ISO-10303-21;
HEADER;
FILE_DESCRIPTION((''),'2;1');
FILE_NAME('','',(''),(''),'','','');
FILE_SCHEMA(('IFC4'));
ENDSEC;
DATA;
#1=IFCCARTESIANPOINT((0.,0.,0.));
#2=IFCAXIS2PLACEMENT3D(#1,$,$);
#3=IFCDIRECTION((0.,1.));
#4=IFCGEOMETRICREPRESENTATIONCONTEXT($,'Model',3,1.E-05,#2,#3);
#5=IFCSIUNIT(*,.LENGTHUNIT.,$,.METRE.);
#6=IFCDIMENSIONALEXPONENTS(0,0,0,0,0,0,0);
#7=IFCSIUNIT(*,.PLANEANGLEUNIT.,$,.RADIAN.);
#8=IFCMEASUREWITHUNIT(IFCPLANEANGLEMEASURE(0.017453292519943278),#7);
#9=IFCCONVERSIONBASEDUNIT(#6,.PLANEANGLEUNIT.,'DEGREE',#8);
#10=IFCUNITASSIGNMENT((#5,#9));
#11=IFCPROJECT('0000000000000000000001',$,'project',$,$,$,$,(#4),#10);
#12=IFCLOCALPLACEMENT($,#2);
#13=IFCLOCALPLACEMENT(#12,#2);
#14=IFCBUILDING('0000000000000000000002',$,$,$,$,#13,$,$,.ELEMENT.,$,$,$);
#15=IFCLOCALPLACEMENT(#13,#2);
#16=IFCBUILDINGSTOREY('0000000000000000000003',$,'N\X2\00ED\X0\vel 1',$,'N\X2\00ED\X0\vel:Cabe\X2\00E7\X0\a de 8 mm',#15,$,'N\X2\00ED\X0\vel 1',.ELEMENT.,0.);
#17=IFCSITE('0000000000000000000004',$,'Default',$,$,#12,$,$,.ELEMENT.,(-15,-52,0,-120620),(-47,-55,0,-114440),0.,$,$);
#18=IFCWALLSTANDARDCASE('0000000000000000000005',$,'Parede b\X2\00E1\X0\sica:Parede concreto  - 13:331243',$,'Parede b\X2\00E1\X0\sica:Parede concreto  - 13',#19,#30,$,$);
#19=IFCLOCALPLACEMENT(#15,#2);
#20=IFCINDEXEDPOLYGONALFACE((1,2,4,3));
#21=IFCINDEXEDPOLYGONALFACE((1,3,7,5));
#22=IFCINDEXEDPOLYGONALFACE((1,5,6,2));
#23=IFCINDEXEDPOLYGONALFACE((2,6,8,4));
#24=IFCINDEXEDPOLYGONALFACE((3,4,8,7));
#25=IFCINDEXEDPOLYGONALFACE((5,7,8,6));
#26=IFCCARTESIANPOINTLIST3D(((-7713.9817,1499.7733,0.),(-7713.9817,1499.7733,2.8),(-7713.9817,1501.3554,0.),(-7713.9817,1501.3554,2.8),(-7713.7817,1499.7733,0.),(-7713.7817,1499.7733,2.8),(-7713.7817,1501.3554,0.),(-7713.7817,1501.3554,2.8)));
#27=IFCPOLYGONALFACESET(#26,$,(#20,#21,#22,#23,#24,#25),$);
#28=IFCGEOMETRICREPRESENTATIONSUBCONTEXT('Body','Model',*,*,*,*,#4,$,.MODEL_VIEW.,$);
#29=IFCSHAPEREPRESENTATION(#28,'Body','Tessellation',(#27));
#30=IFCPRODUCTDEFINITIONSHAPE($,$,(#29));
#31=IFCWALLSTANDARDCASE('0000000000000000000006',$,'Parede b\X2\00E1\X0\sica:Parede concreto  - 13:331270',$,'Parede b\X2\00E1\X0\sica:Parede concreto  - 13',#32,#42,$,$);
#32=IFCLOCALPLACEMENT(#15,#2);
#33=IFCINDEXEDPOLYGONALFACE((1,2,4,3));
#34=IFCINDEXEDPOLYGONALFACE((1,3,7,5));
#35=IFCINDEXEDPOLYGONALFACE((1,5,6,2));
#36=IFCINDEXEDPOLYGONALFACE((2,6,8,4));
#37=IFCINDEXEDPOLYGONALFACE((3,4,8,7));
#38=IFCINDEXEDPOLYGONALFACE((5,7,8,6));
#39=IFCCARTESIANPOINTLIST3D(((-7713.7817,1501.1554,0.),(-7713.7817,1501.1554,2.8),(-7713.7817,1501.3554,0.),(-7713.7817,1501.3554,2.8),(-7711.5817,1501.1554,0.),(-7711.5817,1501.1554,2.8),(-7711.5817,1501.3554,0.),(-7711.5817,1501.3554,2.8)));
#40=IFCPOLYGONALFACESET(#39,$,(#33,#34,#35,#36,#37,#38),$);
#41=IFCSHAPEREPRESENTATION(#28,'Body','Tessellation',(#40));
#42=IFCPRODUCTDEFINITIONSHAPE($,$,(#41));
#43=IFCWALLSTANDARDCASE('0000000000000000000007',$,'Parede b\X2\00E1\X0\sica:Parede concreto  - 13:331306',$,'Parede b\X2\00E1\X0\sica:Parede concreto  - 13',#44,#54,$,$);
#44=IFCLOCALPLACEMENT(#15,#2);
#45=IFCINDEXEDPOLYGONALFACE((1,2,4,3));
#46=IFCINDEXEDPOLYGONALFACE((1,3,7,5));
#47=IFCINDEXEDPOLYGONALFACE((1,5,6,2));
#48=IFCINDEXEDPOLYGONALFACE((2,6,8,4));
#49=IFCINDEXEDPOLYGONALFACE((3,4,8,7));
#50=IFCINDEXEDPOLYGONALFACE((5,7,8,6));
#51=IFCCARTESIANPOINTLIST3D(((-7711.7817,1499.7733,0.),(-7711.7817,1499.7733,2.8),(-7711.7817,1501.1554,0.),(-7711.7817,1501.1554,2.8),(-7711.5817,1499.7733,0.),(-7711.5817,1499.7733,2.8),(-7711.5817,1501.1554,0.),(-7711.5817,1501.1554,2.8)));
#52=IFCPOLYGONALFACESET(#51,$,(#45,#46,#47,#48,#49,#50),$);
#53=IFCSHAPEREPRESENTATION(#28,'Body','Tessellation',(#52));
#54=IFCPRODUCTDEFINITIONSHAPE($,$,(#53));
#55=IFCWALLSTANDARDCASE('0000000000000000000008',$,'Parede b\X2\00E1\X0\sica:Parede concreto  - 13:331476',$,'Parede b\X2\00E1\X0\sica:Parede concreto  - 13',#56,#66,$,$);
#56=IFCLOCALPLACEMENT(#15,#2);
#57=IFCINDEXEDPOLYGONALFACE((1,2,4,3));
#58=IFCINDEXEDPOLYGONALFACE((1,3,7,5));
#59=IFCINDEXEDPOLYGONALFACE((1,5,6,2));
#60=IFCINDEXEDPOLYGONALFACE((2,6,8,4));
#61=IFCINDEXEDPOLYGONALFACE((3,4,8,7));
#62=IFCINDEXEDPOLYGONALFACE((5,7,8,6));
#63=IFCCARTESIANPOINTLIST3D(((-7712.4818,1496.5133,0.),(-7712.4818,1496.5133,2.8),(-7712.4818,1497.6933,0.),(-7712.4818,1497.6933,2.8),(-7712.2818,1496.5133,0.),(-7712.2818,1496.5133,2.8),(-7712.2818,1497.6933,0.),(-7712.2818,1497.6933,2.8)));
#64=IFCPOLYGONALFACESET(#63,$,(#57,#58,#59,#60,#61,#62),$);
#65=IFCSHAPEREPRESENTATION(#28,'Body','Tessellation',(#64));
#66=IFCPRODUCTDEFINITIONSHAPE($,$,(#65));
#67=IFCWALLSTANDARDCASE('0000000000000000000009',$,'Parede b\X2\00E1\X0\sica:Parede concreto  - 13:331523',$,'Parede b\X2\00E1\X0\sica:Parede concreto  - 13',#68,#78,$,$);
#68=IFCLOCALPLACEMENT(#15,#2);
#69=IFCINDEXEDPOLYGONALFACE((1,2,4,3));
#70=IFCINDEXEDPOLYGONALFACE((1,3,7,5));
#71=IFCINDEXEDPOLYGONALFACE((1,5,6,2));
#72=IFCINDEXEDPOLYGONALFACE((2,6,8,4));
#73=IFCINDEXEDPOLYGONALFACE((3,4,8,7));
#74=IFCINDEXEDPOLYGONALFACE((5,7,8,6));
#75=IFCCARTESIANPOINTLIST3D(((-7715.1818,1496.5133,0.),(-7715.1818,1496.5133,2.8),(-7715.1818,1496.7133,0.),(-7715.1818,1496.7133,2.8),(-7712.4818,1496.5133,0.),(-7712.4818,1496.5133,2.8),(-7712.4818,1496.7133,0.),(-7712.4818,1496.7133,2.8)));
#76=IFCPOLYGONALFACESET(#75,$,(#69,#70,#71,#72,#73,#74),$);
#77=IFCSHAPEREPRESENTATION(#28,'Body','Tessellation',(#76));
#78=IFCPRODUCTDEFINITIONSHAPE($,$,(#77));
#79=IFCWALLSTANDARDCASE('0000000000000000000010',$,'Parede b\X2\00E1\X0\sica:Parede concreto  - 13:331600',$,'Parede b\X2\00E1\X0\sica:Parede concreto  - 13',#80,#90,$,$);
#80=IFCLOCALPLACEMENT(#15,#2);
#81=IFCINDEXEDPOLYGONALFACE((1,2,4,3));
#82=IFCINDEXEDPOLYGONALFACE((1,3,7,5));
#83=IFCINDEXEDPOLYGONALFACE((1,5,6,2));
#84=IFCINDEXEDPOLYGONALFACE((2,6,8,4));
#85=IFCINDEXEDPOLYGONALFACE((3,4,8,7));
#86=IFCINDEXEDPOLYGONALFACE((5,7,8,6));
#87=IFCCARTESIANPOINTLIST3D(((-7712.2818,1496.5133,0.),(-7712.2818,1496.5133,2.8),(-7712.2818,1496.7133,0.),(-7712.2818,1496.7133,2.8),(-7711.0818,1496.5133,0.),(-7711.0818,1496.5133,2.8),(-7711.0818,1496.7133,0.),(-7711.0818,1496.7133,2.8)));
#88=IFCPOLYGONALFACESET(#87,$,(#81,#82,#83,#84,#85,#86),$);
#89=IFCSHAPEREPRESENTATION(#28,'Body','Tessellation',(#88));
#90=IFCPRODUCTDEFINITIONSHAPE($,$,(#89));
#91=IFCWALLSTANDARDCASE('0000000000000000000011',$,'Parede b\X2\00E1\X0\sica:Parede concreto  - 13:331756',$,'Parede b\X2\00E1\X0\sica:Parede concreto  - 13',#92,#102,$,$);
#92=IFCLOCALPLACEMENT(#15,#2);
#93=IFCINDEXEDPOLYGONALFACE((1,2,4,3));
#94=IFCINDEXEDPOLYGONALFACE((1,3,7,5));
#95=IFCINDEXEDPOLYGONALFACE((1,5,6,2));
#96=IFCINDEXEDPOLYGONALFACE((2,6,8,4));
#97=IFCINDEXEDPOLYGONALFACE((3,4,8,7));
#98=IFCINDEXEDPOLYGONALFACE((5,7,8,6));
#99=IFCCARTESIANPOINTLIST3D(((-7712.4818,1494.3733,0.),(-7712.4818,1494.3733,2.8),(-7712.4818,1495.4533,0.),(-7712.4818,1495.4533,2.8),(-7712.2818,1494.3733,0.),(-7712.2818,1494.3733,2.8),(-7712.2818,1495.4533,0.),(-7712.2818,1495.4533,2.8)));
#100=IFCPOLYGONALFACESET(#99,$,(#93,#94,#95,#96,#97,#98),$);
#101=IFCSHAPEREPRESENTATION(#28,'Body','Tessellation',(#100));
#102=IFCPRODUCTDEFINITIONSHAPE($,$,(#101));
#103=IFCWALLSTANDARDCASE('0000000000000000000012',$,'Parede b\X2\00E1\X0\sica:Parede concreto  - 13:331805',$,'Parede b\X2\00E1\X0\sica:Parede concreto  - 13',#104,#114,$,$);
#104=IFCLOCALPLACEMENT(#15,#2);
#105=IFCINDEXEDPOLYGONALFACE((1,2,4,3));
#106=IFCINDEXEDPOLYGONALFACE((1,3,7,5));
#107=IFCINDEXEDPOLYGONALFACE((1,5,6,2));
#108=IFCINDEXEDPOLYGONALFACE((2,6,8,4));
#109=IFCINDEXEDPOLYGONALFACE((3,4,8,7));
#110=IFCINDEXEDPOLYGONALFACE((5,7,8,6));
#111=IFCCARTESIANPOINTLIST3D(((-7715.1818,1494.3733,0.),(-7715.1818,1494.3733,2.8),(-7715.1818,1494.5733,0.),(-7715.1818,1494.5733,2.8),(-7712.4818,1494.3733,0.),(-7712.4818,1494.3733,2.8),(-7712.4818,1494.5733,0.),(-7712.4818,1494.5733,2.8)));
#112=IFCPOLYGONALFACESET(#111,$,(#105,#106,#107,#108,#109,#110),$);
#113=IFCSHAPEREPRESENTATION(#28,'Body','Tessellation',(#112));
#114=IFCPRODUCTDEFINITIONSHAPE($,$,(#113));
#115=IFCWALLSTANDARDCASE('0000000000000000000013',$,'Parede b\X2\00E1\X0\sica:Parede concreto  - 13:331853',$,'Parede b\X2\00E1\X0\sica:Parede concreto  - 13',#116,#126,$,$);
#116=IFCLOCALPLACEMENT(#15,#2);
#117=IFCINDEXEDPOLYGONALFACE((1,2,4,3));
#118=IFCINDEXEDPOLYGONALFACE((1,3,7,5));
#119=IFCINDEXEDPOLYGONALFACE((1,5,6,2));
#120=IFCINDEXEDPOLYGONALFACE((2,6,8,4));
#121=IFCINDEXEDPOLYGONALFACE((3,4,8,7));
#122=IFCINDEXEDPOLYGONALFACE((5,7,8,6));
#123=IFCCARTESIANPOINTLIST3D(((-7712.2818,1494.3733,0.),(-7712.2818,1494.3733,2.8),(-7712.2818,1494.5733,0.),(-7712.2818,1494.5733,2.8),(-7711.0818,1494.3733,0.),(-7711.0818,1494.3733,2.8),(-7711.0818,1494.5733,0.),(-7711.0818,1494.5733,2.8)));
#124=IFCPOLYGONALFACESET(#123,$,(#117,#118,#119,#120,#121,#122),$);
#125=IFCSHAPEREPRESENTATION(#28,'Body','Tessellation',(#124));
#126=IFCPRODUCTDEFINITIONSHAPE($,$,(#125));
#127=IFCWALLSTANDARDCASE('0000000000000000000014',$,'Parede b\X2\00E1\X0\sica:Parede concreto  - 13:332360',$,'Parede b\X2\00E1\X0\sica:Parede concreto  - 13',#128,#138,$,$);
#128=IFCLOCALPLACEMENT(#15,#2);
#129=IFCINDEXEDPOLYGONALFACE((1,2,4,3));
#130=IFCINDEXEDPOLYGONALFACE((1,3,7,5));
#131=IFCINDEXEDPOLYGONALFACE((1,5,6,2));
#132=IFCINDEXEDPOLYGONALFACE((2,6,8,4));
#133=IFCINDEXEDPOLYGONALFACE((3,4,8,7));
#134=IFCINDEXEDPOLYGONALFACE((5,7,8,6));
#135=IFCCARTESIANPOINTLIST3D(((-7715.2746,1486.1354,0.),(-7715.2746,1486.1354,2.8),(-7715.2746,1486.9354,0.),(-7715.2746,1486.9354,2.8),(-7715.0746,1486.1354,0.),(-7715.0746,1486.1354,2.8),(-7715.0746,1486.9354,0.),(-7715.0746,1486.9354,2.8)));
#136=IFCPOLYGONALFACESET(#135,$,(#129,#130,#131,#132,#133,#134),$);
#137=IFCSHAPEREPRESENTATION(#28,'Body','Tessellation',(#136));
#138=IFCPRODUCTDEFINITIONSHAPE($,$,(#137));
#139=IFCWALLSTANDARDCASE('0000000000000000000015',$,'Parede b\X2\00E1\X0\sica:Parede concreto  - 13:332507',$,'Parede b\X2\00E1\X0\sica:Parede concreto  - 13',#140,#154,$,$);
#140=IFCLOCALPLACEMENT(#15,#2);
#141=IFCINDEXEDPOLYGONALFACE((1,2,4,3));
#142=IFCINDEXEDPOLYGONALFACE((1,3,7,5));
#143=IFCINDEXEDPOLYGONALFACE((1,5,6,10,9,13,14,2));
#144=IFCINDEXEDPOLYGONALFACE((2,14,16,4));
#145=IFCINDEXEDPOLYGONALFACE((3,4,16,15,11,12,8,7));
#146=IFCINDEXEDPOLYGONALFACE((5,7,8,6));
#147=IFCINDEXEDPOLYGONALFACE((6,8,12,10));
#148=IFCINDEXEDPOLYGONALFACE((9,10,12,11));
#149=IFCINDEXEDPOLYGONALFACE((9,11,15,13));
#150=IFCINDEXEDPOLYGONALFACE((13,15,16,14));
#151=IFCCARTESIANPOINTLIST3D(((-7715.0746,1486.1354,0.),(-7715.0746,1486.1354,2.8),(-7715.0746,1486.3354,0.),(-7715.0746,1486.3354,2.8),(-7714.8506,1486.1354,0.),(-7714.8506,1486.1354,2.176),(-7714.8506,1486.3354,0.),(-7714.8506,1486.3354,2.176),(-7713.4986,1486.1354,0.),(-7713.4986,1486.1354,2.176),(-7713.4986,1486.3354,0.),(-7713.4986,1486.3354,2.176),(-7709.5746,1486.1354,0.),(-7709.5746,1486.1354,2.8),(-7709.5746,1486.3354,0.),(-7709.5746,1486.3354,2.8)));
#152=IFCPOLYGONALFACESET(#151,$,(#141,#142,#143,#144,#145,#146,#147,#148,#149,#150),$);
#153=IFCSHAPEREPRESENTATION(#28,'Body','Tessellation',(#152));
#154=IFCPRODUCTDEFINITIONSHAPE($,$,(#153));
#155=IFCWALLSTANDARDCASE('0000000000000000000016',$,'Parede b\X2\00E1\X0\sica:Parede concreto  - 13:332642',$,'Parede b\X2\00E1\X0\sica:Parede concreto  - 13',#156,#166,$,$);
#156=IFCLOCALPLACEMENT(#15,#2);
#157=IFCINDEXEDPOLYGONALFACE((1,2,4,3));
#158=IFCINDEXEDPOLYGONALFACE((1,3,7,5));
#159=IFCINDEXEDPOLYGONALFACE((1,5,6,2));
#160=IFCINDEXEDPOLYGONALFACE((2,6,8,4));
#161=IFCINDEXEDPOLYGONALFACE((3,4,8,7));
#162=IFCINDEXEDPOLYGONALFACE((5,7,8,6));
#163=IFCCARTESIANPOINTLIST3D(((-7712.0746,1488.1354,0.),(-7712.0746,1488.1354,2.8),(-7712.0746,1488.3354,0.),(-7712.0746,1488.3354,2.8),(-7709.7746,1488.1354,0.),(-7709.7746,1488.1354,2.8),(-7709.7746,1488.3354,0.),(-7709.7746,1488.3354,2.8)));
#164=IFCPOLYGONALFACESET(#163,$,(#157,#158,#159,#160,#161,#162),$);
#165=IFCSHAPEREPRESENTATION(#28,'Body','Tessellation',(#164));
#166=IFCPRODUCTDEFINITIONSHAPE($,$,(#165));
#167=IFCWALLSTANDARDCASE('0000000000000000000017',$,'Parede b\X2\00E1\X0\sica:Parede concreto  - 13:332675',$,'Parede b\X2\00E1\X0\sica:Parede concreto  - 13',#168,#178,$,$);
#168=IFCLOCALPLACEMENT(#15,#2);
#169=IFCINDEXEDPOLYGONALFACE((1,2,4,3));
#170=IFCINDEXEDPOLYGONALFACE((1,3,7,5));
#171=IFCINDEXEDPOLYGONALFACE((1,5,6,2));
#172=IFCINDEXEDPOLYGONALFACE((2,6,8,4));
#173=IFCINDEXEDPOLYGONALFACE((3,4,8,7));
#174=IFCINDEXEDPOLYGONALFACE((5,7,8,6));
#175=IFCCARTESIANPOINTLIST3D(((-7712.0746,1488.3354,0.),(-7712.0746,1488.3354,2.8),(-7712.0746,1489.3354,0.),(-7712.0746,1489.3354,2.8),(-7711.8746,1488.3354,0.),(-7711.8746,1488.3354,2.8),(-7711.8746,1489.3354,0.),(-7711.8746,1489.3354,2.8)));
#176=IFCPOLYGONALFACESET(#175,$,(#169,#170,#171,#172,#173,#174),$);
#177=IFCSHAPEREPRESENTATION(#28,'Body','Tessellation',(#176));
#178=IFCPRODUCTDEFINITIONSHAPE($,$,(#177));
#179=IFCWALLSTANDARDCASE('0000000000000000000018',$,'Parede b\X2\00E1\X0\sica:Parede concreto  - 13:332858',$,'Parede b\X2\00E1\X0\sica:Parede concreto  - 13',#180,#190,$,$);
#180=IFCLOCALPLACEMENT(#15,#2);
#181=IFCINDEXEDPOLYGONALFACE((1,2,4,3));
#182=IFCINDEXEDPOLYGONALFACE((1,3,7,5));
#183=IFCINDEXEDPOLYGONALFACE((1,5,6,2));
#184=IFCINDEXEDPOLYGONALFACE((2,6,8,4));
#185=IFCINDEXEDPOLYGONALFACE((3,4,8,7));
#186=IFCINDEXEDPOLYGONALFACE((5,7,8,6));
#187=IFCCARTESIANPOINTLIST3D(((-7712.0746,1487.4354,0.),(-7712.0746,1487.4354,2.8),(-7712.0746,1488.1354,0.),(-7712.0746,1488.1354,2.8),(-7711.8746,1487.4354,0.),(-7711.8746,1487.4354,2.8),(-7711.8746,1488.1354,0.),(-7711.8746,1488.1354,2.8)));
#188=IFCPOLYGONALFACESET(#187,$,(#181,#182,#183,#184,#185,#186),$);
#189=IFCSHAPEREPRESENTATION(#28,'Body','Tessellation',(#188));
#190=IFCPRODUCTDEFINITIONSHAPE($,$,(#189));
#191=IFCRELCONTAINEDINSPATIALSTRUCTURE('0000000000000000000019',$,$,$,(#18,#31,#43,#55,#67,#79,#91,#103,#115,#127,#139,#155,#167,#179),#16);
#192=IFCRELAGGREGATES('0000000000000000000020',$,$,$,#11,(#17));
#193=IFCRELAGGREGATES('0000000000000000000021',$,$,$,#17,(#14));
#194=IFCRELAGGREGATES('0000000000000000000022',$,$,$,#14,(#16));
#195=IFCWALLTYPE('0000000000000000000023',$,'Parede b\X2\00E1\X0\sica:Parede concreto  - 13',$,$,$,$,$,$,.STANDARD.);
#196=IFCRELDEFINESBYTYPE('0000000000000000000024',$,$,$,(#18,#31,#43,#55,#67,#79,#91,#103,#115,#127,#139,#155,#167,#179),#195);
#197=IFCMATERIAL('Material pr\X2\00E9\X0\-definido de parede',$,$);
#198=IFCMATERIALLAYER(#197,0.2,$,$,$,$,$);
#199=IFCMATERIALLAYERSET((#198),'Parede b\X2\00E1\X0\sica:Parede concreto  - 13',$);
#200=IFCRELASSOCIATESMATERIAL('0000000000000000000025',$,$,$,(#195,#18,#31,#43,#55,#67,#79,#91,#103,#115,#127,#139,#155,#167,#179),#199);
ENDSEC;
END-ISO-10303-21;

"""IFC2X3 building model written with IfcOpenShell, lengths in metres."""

from ifc_helpers import new_model, entity, si_unit, converted_unit, direction, frame, frame_2d, origin, place, context, subcontext, project, spatial, rectangle, extrude, material, layer, layer_set, layer_usage, type_object, element, save


model = new_model("IFC2X3")

# Units and contexts
model_context = context("Model", 3, precision=1e-05, world=origin(), true_north=direction((0.0, 1.0)))
body_context = subcontext(model_context, "Body", "Model", "MODEL_VIEW")
ifc_project = project(units=[si_unit("LENGTHUNIT", "METRE"), converted_unit("PLANEANGLEUNIT", "DEGREE", entity("IfcPlaneAngleMeasure", 0.017453292519943278), si_unit("PLANEANGLEUNIT", "RADIAN"), dimensions=[0, 0, 0, 0, 0, 0, 0])], contexts=[model_context])

# Site, building, storey
site_placement = place(None, origin())
site = spatial("IfcSite", under=ifc_project, at=site_placement, Name="Default", CompositionType="ELEMENT", RefLatitude=(-15, -52, 0, -120620), RefLongitude=(-47, -55, 0, -114440), RefElevation=0.0)
building_placement = place(site_placement, origin())
building = spatial("IfcBuilding", under=site, at=building_placement, CompositionType="ELEMENT")
storey_placement = place(building_placement, origin())
storey = spatial("IfcBuildingStorey", under=building, at=storey_placement, Name="Nível 1", ObjectType="Nível:Cabeça de 8 mm", LongName="Nível 1", CompositionType="ELEMENT", Elevation=0.0)

# Walls
ifc_material = material(Name="Material pré-definido de parede")
ifc_layer = layer(ifc_material, 0.2)
ifc_layer_set = layer_set([ifc_layer], Name="Parede básica:Parede concreto  - 13")
ifc_layer_usage_1 = layer_usage(ifc_layer_set, "AXIS2", "NEGATIVE", 0.1)
wall_type = type_object("IfcWallType", Name="Parede básica:Parede concreto  - 13", PredefinedType="STANDARD", material=ifc_layer_set)
wall_1_placement = place(storey_placement, frame((-7713.8817, 1499.7733, 0.0), z_axis=(0.0, 0.0, 1.0), x_axis=(0.0, 1.0, 0.0)))
element("IfcWallStandardCase", 1, at=wall_1_placement, inside=storey, type_object=wall_type, material=ifc_layer_usage_1, Name="Parede básica:Parede concreto  - 13:331243", ObjectType="Parede básica:Parede concreto  - 13", context=body_context, shape_type="SweptSolid", body=[
    extrude(rectangle(XDim=1.5821, YDim=0.2, at=frame_2d((0.791, 0.0), x_axis=(-1.0, 0.0))), origin(), (0.0, 0.0, 1.0), 2.8),
])
ifc_layer_usage_2 = layer_usage(ifc_layer_set, "AXIS2", "NEGATIVE", 0.1)
wall_2_placement = place(storey_placement, frame((-7713.7817, 1501.2554, 0.0)))
element("IfcWallStandardCase", 2, at=wall_2_placement, inside=storey, type_object=wall_type, material=ifc_layer_usage_2, Name="Parede básica:Parede concreto  - 13:331270", ObjectType="Parede básica:Parede concreto  - 13", context=body_context, shape_type="SweptSolid", body=[
    extrude(rectangle(XDim=2.2, YDim=0.2, at=frame_2d((1.1, 0.0), x_axis=(-1.0, 0.0))), origin(), (0.0, 0.0, 1.0), 2.8),
])
ifc_layer_usage_3 = layer_usage(ifc_layer_set, "AXIS2", "NEGATIVE", 0.1)
wall_3_placement = place(storey_placement, frame((-7711.6817, 1501.1554, 0.0), z_axis=(0.0, 0.0, 1.0), x_axis=(0.0, -1.0, 0.0)))
element("IfcWallStandardCase", 3, at=wall_3_placement, inside=storey, type_object=wall_type, material=ifc_layer_usage_3, Name="Parede básica:Parede concreto  - 13:331306", ObjectType="Parede básica:Parede concreto  - 13", context=body_context, shape_type="SweptSolid", body=[
    extrude(rectangle(XDim=1.3821, YDim=0.2, at=frame_2d((0.691, 0.0), x_axis=(-1.0, 0.0))), origin(), (0.0, 0.0, 1.0), 2.8),
])
ifc_layer_usage_4 = layer_usage(ifc_layer_set, "AXIS2", "NEGATIVE", 0.1)
wall_4_placement = place(storey_placement, frame((-7712.3818, 1497.6933, 0.0), z_axis=(0.0, 0.0, 1.0), x_axis=(0.0, -1.0, 0.0)))
element("IfcWallStandardCase", 4, at=wall_4_placement, inside=storey, type_object=wall_type, material=ifc_layer_usage_4, Name="Parede básica:Parede concreto  - 13:331476", ObjectType="Parede básica:Parede concreto  - 13", context=body_context, shape_type="SweptSolid", body=[
    extrude(rectangle(XDim=1.18, YDim=0.2, at=frame_2d((0.59, 0.0), x_axis=(-1.0, 0.0))), origin(), (0.0, 0.0, 1.0), 2.8),
])
ifc_layer_usage_5 = layer_usage(ifc_layer_set, "AXIS2", "NEGATIVE", 0.1)
wall_5_placement = place(storey_placement, frame((-7712.4818, 1496.6133, 0.0), z_axis=(0.0, 0.0, 1.0), x_axis=(-1.0, 0.0, 0.0)))
element("IfcWallStandardCase", 5, at=wall_5_placement, inside=storey, type_object=wall_type, material=ifc_layer_usage_5, Name="Parede básica:Parede concreto  - 13:331523", ObjectType="Parede básica:Parede concreto  - 13", context=body_context, shape_type="SweptSolid", body=[
    extrude(rectangle(XDim=2.7, YDim=0.2, at=frame_2d((1.35, 0.0), x_axis=(-1.0, 0.0))), origin(), (0.0, 0.0, 1.0), 2.8),
])
ifc_layer_usage_6 = layer_usage(ifc_layer_set, "AXIS2", "POSITIVE", -0.1)
wall_6_placement = place(storey_placement, frame((-7712.2818, 1496.6133, 0.0)))
element("IfcWallStandardCase", 6, at=wall_6_placement, inside=storey, type_object=wall_type, material=ifc_layer_usage_6, Name="Parede básica:Parede concreto  - 13:331600", ObjectType="Parede básica:Parede concreto  - 13", context=body_context, shape_type="SweptSolid", body=[
    extrude(rectangle(XDim=1.2, YDim=0.2, at=frame_2d((0.6, 0.0), x_axis=(-1.0, 0.0))), origin(), (0.0, 0.0, 1.0), 2.8),
])
ifc_layer_usage_7 = layer_usage(ifc_layer_set, "AXIS2", "NEGATIVE", 0.1)
wall_7_placement = place(storey_placement, frame((-7712.3818, 1495.4533, 0.0), z_axis=(0.0, 0.0, 1.0), x_axis=(0.0, -1.0, 0.0)))
element("IfcWallStandardCase", 7, at=wall_7_placement, inside=storey, type_object=wall_type, material=ifc_layer_usage_7, Name="Parede básica:Parede concreto  - 13:331756", ObjectType="Parede básica:Parede concreto  - 13", context=body_context, shape_type="SweptSolid", body=[
    extrude(rectangle(XDim=1.08, YDim=0.2, at=frame_2d((0.54, 0.0), x_axis=(-1.0, 0.0))), origin(), (0.0, 0.0, 1.0), 2.8),
])
ifc_layer_usage_8 = layer_usage(ifc_layer_set, "AXIS2", "NEGATIVE", 0.1)
wall_8_placement = place(storey_placement, frame((-7712.4818, 1494.4733, 0.0), z_axis=(0.0, 0.0, 1.0), x_axis=(-1.0, 0.0, 0.0)))
element("IfcWallStandardCase", 8, at=wall_8_placement, inside=storey, type_object=wall_type, material=ifc_layer_usage_8, Name="Parede básica:Parede concreto  - 13:331805", ObjectType="Parede básica:Parede concreto  - 13", context=body_context, shape_type="SweptSolid", body=[
    extrude(rectangle(XDim=2.7, YDim=0.2, at=frame_2d((1.35, 0.0), x_axis=(-1.0, 0.0))), origin(), (0.0, 0.0, 1.0), 2.8),
])
ifc_layer_usage_9 = layer_usage(ifc_layer_set, "AXIS2", "POSITIVE", -0.1)
wall_9_placement = place(storey_placement, frame((-7712.2818, 1494.4733, 0.0)))
element("IfcWallStandardCase", 9, at=wall_9_placement, inside=storey, type_object=wall_type, material=ifc_layer_usage_9, Name="Parede básica:Parede concreto  - 13:331853", ObjectType="Parede básica:Parede concreto  - 13", context=body_context, shape_type="SweptSolid", body=[
    extrude(rectangle(XDim=1.2, YDim=0.2, at=frame_2d((0.6, 0.0), x_axis=(-1.0, 0.0))), origin(), (0.0, 0.0, 1.0), 2.8),
])
ifc_layer_usage_10 = layer_usage(ifc_layer_set, "AXIS2", "POSITIVE", -0.1)
wall_10_placement = place(storey_placement, frame((-7715.1746, 1486.9354, 0.0), z_axis=(0.0, 0.0, 1.0), x_axis=(0.0, -1.0, 0.0)))
element("IfcWallStandardCase", 10, at=wall_10_placement, inside=storey, type_object=wall_type, material=ifc_layer_usage_10, Name="Parede básica:Parede concreto  - 13:332360", ObjectType="Parede básica:Parede concreto  - 13", context=body_context, shape_type="SweptSolid", body=[
    extrude(rectangle(XDim=0.8, YDim=0.2, at=frame_2d((0.4, 0.0), x_axis=(-1.0, 0.0))), origin(), (0.0, 0.0, 1.0), 2.8),
])

# Wall, opening
ifc_layer_usage_11 = layer_usage(ifc_layer_set, "AXIS2", "NEGATIVE", 0.1)
wall_11_placement = place(storey_placement, frame((-7715.0746, 1486.2354, 0.0)))
wall_11 = element("IfcWallStandardCase", 11, at=wall_11_placement, inside=storey, type_object=wall_type, material=ifc_layer_usage_11, Name="Parede básica:Parede concreto  - 13:332507", ObjectType="Parede básica:Parede concreto  - 13", context=body_context, shape_type="SweptSolid", body=[
    extrude(rectangle(XDim=5.5, YDim=0.2, at=frame_2d((2.75, 0.0), x_axis=(-1.0, 0.0))), origin(), (0.0, 0.0, 1.0), 2.8),
])
opening_1_placement = place(wall_11_placement, origin())
element("IfcOpeningElement", 12, at=opening_1_placement, cuts=wall_11, ObjectType="Opening", context=body_context, shape_type="SweptSolid", body=[
    extrude(rectangle(XDim=2.176, YDim=1.352, at=frame_2d((0.0, 0.0), x_axis=(0.0, 1.0))), frame((0.9, 0.1, 1.088), z_axis=(0.0, -1.0, 0.0), x_axis=(1.0, 0.0, 0.0)), (0.0, 0.0, 1.0), 0.2),
])

# Walls
ifc_layer_usage_12 = layer_usage(ifc_layer_set, "AXIS2", "NEGATIVE", 0.1)
wall_12_placement = place(storey_placement, frame((-7709.7746, 1488.2354, 0.0), z_axis=(0.0, 0.0, 1.0), x_axis=(-1.0, 0.0, 0.0)))
element("IfcWallStandardCase", 13, at=wall_12_placement, inside=storey, type_object=wall_type, material=ifc_layer_usage_12, Name="Parede básica:Parede concreto  - 13:332642", ObjectType="Parede básica:Parede concreto  - 13", context=body_context, shape_type="SweptSolid", body=[
    extrude(rectangle(XDim=2.3, YDim=0.2, at=frame_2d((1.15, 0.0), x_axis=(-1.0, 0.0))), origin(), (0.0, 0.0, 1.0), 2.8),
])
ifc_layer_usage_13 = layer_usage(ifc_layer_set, "AXIS2", "NEGATIVE", 0.1)
wall_13_placement = place(storey_placement, frame((-7711.9746, 1488.3354, 0.0), z_axis=(0.0, 0.0, 1.0), x_axis=(0.0, 1.0, 0.0)))
element("IfcWallStandardCase", 14, at=wall_13_placement, inside=storey, type_object=wall_type, material=ifc_layer_usage_13, Name="Parede básica:Parede concreto  - 13:332675", ObjectType="Parede básica:Parede concreto  - 13", context=body_context, shape_type="SweptSolid", body=[
    extrude(rectangle(XDim=1.0, YDim=0.2, at=frame_2d((0.5, 0.0), x_axis=(-1.0, 0.0))), origin(), (0.0, 0.0, 1.0), 2.8),
])
ifc_layer_usage_14 = layer_usage(ifc_layer_set, "AXIS2", "POSITIVE", -0.1)
wall_14_placement = place(storey_placement, frame((-7711.9746, 1488.1354, 0.0), z_axis=(0.0, 0.0, 1.0), x_axis=(0.0, -1.0, 0.0)))
element("IfcWallStandardCase", 15, at=wall_14_placement, inside=storey, type_object=wall_type, material=ifc_layer_usage_14, Name="Parede básica:Parede concreto  - 13:332858", ObjectType="Parede básica:Parede concreto  - 13", context=body_context, shape_type="SweptSolid", body=[
    extrude(rectangle(XDim=0.7, YDim=0.2, at=frame_2d((0.35, 0.0), x_axis=(-1.0, 0.0))), origin(), (0.0, 0.0, 1.0), 2.8),
])

save(model, "model.ifc")
